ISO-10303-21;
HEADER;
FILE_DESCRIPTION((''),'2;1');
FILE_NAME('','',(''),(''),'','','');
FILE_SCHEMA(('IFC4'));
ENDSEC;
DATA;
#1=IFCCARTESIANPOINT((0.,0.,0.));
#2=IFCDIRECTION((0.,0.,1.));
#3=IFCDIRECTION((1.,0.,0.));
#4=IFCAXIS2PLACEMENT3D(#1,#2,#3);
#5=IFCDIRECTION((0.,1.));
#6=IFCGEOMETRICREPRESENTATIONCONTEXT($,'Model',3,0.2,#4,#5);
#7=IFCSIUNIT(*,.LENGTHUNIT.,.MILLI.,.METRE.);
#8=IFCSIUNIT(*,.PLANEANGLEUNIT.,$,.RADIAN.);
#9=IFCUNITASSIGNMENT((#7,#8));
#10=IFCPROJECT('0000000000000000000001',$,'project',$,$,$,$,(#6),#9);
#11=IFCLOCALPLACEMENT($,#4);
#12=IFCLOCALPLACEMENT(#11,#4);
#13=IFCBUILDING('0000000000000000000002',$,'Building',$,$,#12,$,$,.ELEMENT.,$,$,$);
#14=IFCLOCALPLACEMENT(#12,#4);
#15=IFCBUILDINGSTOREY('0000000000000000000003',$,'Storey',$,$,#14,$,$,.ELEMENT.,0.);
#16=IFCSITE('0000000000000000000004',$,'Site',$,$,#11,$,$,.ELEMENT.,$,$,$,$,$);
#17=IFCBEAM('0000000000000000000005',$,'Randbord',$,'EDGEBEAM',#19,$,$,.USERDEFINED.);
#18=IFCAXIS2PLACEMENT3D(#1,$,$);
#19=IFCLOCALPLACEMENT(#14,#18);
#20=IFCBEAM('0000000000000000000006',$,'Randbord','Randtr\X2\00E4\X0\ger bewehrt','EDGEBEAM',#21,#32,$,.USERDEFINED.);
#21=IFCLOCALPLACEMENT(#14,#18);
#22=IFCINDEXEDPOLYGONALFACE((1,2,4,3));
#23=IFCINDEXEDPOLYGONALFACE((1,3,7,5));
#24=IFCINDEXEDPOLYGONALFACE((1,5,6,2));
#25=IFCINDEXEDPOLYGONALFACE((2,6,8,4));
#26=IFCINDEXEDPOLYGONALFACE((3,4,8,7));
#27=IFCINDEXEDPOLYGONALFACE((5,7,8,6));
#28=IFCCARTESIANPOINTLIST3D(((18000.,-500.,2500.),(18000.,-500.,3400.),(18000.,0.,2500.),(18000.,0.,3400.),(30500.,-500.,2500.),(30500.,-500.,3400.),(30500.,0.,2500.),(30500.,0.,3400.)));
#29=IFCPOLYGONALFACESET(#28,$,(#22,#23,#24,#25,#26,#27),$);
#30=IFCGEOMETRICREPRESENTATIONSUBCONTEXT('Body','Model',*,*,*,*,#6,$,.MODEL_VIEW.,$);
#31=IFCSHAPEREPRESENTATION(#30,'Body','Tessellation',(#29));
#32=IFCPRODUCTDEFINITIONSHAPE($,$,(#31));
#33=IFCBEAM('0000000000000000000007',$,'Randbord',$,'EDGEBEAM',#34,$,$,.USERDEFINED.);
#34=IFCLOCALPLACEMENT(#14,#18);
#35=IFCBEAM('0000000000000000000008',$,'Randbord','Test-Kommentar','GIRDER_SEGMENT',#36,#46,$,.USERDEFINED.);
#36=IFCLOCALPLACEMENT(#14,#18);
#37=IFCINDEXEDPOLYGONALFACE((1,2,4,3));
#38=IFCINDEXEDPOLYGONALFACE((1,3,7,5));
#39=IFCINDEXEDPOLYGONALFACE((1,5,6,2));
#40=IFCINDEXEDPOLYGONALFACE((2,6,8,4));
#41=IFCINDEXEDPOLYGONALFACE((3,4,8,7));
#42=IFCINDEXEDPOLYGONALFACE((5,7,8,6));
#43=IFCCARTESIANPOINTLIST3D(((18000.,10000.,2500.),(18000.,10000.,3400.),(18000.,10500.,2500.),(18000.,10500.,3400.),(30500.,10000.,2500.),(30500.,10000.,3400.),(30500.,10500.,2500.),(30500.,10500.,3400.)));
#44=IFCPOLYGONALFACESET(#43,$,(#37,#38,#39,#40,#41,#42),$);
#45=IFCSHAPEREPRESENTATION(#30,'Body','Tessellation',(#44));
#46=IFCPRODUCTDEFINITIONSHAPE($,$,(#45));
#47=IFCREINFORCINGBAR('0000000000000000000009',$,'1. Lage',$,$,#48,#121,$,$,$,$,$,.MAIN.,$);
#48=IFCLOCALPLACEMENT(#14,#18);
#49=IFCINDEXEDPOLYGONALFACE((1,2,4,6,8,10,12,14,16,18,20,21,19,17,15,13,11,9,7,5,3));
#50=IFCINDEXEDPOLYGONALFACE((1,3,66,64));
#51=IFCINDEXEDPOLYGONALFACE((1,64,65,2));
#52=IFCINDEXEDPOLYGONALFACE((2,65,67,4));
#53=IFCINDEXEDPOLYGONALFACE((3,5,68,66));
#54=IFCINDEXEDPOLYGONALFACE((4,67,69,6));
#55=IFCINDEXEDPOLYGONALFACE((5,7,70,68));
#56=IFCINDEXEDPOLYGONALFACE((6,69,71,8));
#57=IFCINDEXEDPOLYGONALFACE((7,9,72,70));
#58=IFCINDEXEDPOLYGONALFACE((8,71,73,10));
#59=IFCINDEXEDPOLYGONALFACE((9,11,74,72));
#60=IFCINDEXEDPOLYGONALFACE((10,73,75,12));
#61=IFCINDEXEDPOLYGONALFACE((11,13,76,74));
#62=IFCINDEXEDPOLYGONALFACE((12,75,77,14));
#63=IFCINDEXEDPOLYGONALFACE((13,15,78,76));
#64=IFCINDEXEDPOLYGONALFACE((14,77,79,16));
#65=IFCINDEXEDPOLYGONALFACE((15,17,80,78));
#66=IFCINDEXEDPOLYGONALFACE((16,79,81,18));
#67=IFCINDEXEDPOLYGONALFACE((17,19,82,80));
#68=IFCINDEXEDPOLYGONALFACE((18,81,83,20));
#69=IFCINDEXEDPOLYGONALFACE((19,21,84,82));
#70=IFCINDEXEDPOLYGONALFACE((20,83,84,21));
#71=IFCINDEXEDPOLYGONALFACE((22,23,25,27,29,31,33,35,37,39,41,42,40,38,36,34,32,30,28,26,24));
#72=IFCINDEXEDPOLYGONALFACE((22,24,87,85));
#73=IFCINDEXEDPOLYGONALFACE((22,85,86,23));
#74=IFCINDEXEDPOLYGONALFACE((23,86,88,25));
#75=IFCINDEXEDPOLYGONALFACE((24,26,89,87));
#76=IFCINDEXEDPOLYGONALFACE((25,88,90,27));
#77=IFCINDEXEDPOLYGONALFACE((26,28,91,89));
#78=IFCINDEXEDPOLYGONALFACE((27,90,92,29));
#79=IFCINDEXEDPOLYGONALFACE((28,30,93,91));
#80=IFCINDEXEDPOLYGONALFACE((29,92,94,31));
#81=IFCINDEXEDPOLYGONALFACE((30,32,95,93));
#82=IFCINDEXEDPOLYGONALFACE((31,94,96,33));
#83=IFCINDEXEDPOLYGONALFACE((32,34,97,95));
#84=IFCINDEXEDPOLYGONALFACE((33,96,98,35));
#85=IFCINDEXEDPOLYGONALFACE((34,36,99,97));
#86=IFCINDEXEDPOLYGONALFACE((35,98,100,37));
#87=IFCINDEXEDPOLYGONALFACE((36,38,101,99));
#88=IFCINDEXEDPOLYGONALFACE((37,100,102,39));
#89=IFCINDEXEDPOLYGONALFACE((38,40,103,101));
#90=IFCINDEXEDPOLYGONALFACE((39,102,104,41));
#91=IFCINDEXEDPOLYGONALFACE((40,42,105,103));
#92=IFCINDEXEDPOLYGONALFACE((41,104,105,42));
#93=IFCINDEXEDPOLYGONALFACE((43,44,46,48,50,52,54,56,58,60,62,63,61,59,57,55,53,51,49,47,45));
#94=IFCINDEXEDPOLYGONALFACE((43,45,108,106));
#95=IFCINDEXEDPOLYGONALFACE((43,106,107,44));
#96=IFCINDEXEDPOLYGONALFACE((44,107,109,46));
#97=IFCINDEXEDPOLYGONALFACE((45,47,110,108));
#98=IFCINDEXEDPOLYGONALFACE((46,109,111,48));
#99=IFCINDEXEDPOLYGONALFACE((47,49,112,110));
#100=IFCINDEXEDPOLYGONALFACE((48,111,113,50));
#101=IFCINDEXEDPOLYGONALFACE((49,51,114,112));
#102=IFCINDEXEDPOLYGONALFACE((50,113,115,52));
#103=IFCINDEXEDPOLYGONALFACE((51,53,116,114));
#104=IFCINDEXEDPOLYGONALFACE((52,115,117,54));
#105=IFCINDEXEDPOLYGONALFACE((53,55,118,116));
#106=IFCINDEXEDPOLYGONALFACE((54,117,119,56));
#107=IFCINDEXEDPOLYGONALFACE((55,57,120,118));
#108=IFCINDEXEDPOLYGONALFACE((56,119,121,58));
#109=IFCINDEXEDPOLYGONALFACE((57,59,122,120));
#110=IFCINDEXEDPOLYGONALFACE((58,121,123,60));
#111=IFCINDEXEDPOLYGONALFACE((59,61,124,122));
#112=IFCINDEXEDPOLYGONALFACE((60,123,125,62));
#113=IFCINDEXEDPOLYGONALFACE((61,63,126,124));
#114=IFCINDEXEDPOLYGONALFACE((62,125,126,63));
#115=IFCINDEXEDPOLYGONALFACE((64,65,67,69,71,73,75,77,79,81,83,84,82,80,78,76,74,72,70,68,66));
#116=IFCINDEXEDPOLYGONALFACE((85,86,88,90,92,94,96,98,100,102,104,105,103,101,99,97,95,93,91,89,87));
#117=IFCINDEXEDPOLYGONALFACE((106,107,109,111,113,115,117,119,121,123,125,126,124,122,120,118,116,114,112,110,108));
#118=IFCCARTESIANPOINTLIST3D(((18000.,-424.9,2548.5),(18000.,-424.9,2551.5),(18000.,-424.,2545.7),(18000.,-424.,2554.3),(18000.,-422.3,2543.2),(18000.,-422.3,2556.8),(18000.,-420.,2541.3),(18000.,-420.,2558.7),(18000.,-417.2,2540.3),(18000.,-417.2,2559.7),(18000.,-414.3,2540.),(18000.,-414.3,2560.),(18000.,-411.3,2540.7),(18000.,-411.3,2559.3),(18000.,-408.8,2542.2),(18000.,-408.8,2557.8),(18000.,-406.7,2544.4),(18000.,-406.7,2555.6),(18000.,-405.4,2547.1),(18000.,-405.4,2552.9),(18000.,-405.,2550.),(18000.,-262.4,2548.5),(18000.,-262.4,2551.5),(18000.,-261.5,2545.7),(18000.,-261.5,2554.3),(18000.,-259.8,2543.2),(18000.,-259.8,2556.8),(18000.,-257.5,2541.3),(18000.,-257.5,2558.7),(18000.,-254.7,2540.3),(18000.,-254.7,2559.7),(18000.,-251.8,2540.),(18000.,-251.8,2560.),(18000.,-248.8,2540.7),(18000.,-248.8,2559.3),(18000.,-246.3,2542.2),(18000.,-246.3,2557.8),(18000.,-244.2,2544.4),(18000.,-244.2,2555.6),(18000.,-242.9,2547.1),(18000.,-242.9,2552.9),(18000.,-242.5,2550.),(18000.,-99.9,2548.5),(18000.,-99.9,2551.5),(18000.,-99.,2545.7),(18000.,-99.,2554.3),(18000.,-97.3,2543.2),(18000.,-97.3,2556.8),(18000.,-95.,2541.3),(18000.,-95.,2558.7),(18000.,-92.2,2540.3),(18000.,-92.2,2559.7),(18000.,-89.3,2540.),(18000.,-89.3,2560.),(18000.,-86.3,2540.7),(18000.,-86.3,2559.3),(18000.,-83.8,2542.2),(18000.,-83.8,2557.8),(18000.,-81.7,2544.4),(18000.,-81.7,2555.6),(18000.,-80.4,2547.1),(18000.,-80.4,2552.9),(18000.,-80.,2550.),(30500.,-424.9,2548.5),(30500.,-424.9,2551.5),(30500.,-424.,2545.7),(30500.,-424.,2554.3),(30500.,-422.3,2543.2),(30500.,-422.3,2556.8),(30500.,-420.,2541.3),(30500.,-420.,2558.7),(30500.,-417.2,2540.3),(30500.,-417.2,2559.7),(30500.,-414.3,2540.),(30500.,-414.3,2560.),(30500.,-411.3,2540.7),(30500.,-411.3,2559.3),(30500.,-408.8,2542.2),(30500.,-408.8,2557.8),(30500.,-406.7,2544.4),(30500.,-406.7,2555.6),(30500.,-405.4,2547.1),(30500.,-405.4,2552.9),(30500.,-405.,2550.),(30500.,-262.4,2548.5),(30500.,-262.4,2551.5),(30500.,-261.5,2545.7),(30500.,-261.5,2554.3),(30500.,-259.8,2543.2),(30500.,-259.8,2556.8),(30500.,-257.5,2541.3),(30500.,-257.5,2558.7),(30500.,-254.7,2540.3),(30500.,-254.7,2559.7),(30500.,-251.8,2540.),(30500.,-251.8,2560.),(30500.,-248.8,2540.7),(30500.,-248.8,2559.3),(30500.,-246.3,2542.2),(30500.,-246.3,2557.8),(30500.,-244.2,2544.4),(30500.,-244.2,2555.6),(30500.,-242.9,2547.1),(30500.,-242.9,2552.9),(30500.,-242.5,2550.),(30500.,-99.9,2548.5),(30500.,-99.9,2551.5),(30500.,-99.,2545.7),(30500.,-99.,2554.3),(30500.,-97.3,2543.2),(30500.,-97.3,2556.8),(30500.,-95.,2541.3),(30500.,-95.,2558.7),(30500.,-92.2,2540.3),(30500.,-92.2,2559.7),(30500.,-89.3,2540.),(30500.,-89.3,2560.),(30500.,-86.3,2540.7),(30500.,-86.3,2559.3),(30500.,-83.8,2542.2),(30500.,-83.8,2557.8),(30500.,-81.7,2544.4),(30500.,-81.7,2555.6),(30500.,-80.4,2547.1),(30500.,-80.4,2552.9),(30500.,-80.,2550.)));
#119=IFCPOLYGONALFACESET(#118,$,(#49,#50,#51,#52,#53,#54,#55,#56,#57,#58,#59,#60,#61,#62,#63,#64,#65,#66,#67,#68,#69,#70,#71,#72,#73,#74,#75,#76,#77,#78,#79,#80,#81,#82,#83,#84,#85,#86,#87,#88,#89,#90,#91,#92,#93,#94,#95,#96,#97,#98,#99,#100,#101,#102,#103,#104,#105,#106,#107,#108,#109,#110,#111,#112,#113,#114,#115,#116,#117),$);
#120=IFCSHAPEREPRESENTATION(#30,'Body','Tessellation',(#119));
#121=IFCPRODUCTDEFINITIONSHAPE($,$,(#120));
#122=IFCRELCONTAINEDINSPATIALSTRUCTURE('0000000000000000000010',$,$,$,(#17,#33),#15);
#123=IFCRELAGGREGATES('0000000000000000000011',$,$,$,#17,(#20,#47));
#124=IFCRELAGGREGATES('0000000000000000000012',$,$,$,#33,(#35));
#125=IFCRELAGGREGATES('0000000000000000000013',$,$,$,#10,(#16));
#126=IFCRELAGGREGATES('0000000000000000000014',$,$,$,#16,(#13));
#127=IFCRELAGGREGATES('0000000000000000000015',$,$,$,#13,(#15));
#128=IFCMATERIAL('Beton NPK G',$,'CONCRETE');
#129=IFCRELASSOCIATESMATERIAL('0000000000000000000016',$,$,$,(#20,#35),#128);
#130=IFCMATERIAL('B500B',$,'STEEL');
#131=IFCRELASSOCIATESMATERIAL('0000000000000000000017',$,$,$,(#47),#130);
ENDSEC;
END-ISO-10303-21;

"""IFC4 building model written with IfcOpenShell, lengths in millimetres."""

from ifc_helpers import new_model, entity, si_unit, direction, frame, origin_with_axes, place, context, subcontext, project, spatial, line, indexed_curve, outline, extrude, source, transform, mapped, material, element, aggregate, save


model = new_model("IFC4")

# Units and contexts
model_context = context("Model", 3, precision=0.2, world=origin_with_axes(), true_north=direction((0.0, 1.0)))
body_context = subcontext(model_context, "Body", "Model", "MODEL_VIEW")
ifc_project = project(units=[si_unit("LENGTHUNIT", "METRE", prefix="MILLI"), si_unit("PLANEANGLEUNIT", "RADIAN")], contexts=[model_context])

# Site, building, storey
site_placement = place(None, origin_with_axes())
site = spatial("IfcSite", under=ifc_project, at=site_placement, Name="Site", CompositionType="ELEMENT")
building_placement = place(site_placement, origin_with_axes())
building = spatial("IfcBuilding", under=site, at=building_placement, Name="Building", CompositionType="ELEMENT")
storey_placement = place(building_placement, origin_with_axes())
storey = spatial("IfcBuildingStorey", under=building, at=storey_placement, Name="Storey", CompositionType="ELEMENT", Elevation=0.0)

# Beams
beam_1_placement = place(storey_placement, frame((30500.0, -250.0, 2950.0), z_axis=(0.0, 1.0, 0.0), x_axis=(-1.0, 0.0, 0.0)))
beam_1 = element("IfcBeam", 1, at=beam_1_placement, inside=storey, Name="Randbord", ObjectType="EDGEBEAM", PredefinedType="USERDEFINED")
ifc_material_1 = material(Name="Beton NPK G", Category="CONCRETE")
beam_2_placement = place(beam_1_placement, origin_with_axes())
beam_2 = element("IfcBeam", 2, at=beam_2_placement, material=ifc_material_1, Name="Randbord", Description="Randträger bewehrt", ObjectType="EDGEBEAM", PredefinedType="USERDEFINED", context=body_context, shape_type="SolidModel", body=[
    extrude(outline(indexed_curve([(-250.0, -450.0), (250.0, -450.0), (250.0, 450.0), (-250.0, 450.0)], segments=[line(1, 2, 3, 4, 1)])), frame((0.0, 0.0, 0.0), z_axis=(-1.0, 0.0, 0.0), x_axis=(0.0, 0.0, 1.0)), (0.0, 0.0, -1.0), 12500.0),
])
beam_3_placement = place(storey_placement, frame((30500.0, 10250.0, 2950.0), z_axis=(0.0, 1.0, 0.0), x_axis=(-1.0, 0.0, 0.0)))
beam_3 = element("IfcBeam", 3, at=beam_3_placement, inside=storey, Name="Randbord", ObjectType="EDGEBEAM", PredefinedType="USERDEFINED")
beam_4_placement = place(beam_3_placement, origin_with_axes())
beam_4 = element("IfcBeam", 4, at=beam_4_placement, material=ifc_material_1, Name="Randbord", Description="Test-Kommentar", ObjectType="GIRDER_SEGMENT", PredefinedType="USERDEFINED", context=body_context, shape_type="SolidModel", body=[
    extrude(outline(indexed_curve([(-250.0, -450.0), (250.0, -450.0), (250.0, 450.0), (-250.0, 450.0)], segments=[line(1, 2, 3, 4, 1)])), frame((0.0, 0.0, 0.0), z_axis=(-1.0, 0.0, 0.0), x_axis=(0.0, 0.0, 1.0)), (0.0, 0.0, -1.0), 12500.0),
])

# Reinforcing bar
ifc_material_2 = material(Name="B500B", Category="STEEL")
shared_shape_1 = source(origin_with_axes(), body_context, "Body", "AdvancedSweptSolid", [
    entity("IfcSweptDiskSolid", entity("IfcIndexedPolyCurve", entity("IfcCartesianPointList3D", [[0.0, 0.0, 0.0], [12500.0, 0.0, 0.0]]), [entity("IfcLineIndex", [1, 2])]), 10.0),
])
reinforcing_bar_1_placement = place(beam_1_placement, frame((0.0, -400.0, -165.0), z_axis=(0.0, 0.0, 1.0), x_axis=(1.0, 0.0, 0.0)))
reinforcing_bar_1 = element("IfcReinforcingBar", 5, at=reinforcing_bar_1_placement, material=ifc_material_2, Name="1. Lage", PredefinedType="MAIN", context=body_context, shape_type="MappedRepresentation", body=[
    mapped(shared_shape_1, transform((0.0, 0.0, 0.0))),
    mapped(shared_shape_1, transform((0.0, 0.0, 162.5))),
    mapped(shared_shape_1, transform((0.0, 0.0, 325.0))),
])
aggregate(beam_1, [beam_2, reinforcing_bar_1])
aggregate(beam_3, [beam_4])

save(model, "model.ifc")
